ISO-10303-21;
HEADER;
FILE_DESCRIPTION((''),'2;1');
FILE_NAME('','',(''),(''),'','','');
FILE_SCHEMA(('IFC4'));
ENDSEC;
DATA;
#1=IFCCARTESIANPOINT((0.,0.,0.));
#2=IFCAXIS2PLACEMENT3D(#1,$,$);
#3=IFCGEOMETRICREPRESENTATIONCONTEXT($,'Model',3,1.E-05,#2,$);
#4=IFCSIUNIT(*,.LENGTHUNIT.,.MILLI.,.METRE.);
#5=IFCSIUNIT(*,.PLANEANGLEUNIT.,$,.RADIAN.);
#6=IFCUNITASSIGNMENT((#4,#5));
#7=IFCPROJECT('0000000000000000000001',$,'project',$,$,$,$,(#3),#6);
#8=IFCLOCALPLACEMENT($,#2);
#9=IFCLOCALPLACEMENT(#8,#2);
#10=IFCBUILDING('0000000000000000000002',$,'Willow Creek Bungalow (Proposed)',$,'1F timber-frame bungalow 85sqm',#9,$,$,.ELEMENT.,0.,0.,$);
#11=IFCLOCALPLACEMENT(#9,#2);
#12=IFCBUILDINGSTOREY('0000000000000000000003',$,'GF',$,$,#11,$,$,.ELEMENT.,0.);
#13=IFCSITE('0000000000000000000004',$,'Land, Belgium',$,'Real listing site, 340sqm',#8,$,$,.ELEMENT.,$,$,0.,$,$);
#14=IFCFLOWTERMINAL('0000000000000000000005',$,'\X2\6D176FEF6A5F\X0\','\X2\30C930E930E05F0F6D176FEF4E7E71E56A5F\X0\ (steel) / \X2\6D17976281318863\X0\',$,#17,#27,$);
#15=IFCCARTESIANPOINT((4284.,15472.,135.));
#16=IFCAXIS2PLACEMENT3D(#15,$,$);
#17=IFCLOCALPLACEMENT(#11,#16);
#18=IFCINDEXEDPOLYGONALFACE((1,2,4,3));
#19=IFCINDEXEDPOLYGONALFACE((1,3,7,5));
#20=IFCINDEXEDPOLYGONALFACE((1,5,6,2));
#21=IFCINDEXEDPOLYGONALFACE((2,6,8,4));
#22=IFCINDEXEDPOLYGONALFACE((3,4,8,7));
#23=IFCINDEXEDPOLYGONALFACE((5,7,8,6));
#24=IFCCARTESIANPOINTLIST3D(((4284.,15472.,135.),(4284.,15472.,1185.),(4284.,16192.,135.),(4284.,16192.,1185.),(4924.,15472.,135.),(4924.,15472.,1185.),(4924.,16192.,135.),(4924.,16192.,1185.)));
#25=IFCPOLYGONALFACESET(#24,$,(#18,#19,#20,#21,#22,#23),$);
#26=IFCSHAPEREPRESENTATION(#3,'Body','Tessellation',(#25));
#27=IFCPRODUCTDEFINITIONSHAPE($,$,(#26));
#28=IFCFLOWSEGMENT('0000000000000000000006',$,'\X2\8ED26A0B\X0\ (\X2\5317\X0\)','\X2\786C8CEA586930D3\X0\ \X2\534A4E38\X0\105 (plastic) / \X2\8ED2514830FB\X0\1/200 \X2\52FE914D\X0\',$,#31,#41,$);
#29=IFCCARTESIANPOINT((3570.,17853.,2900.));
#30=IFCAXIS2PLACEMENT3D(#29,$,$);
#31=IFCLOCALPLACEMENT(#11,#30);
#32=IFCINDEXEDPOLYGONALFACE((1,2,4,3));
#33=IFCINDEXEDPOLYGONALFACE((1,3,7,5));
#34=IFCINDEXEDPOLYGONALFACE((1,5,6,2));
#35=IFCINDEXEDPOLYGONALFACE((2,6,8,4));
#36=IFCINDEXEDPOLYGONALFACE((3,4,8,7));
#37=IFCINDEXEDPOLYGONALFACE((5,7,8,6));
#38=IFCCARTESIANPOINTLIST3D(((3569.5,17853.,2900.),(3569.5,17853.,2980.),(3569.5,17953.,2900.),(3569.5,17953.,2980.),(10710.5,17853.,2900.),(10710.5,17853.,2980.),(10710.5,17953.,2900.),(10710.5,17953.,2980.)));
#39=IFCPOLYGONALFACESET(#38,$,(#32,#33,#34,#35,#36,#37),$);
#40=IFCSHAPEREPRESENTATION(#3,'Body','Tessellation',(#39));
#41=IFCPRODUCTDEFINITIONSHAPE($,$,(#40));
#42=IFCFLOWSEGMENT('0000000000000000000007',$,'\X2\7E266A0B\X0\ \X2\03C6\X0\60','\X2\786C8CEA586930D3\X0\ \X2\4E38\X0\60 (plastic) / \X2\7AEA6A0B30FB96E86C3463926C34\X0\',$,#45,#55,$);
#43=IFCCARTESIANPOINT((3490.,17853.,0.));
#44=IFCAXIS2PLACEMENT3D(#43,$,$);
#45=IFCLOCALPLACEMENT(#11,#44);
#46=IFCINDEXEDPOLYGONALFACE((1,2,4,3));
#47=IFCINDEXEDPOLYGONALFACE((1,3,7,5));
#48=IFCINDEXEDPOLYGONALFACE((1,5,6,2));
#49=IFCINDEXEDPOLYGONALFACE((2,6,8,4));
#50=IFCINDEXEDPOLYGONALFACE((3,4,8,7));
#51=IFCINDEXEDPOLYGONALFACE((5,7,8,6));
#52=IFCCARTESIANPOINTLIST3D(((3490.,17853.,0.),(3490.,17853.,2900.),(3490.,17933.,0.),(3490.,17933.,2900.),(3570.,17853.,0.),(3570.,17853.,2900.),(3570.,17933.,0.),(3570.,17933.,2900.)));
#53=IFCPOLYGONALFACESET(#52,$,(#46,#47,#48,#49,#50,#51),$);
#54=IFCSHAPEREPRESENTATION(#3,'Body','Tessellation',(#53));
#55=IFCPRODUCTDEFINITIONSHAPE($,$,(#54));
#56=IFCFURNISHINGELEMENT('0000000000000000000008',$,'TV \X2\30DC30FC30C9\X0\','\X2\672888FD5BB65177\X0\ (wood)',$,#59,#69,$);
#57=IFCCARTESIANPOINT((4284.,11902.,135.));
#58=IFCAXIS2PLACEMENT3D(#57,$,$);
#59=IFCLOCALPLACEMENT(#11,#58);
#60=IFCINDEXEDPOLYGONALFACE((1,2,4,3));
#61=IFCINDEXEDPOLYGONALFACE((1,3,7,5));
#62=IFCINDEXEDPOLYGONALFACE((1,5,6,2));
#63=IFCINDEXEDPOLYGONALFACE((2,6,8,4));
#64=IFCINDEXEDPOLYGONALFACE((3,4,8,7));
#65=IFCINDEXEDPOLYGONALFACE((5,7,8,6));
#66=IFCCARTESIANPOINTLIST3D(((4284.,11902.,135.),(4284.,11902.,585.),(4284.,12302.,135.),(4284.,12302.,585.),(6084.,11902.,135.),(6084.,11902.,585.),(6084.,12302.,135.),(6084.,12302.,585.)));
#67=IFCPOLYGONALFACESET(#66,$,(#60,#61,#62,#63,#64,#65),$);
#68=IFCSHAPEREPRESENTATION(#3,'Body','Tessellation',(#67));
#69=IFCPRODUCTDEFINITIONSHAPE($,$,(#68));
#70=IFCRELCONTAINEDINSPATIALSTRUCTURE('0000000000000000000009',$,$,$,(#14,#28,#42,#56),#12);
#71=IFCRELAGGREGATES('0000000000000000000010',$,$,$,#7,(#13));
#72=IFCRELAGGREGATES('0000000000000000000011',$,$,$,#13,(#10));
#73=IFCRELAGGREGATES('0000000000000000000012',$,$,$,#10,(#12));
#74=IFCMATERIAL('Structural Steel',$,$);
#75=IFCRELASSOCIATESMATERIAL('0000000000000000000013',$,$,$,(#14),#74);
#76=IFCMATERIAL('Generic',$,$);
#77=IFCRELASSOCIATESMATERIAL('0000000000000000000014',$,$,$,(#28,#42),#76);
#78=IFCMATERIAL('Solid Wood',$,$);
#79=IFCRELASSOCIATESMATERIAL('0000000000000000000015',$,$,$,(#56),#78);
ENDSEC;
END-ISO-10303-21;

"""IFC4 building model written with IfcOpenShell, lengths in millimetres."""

from ifc_helpers import new_model, si_unit, frame, frame_2d, origin, place, context, project, spatial, rectangle, extrude, material, element, save


model = new_model("IFC4")

# Units and contexts
model_context = context("Model", 3, precision=1e-05, world=origin())
ifc_project = project(units=[si_unit("LENGTHUNIT", "METRE", prefix="MILLI"), si_unit("PLANEANGLEUNIT", "RADIAN")], contexts=[model_context])

# Site, building, storey
site_placement = place(None, origin())
site = spatial("IfcSite", under=ifc_project, at=site_placement, Name="Land, Belgium", ObjectType="Real listing site, 340sqm", CompositionType="ELEMENT", RefElevation=0.0)
building_placement = place(site_placement, origin())
building = spatial("IfcBuilding", under=site, at=building_placement, Name="Willow Creek Bungalow (Proposed)", ObjectType="1F timber-frame bungalow 85sqm", CompositionType="ELEMENT", ElevationOfRefHeight=0.0, ElevationOfTerrain=0.0)
storey_placement = place(building_placement, origin())
storey = spatial("IfcBuildingStorey", under=building, at=storey_placement, Name="GF", CompositionType="ELEMENT", Elevation=0.0)

# Shared definitions
ifc_material_1 = material(Name="Solid Wood")

# Shared definitions
ifc_material_2 = material(Name="Structural Steel")

# Shared definitions
ifc_material_3 = material(Name="Generic")

# Flow terminal
flow_terminal_placement = place(storey_placement, frame((4284.0, 15472.0, 135.0)))
element("IfcFlowTerminal", 1, at=flow_terminal_placement, inside=storey, material=ifc_material_2, Name="洗濯機", Description="ドラム式洗濯乾燥機 (steel) / 洗面脱衣", context=model_context, shape_type="SweptSolid", body=[
    extrude(rectangle(XDim=640.0, YDim=720.0, at=frame_2d((320.0, 360.0))), frame((4284.0, 15472.0, 135.0)), (0.0, 0.0, 1.0), 1050.0),
])

# Flow segments
flow_segment_1_placement = place(storey_placement, frame((3570.0, 17853.0, 2900.0)))
element("IfcFlowSegment", 2, at=flow_segment_1_placement, inside=storey, material=ifc_material_3, Name="軒樋 (北)", Description="硬質塩ビ 半丸105 (plastic) / 軒先・1/200 勾配", context=model_context, shape_type="SweptSolid", body=[
    extrude(rectangle(XDim=7141.0, YDim=100.0, at=frame_2d((3570.0, 50.0))), frame((3570.0, 17853.0, 2900.0)), (0.0, 0.0, 1.0), 80.0),
])
flow_segment_2_placement = place(storey_placement, frame((3490.0, 17853.0, 0.0)))
element("IfcFlowSegment", 3, at=flow_segment_2_placement, inside=storey, material=ifc_material_3, Name="縦樋 φ60", Description="硬質塩ビ 丸60 (plastic) / 竪樋・雨水排水", context=model_context, shape_type="SweptSolid", body=[
    extrude(rectangle(XDim=80.0, YDim=80.0, at=frame_2d((40.0, 40.0))), frame((3490.0, 17853.0, 0.0)), (0.0, 0.0, 1.0), 2900.0),
])

# Furnishing element
furnishing_placement = place(storey_placement, frame((4284.0, 11902.0, 135.0)))
element("IfcFurnishingElement", 4, at=furnishing_placement, inside=storey, material=ifc_material_1, Name="TV ボード", Description="木製家具 (wood)", context=model_context, shape_type="SweptSolid", body=[
    extrude(rectangle(XDim=1800.0, YDim=400.0, at=frame_2d((900.0, 200.0))), frame((4284.0, 11902.0, 135.0)), (0.0, 0.0, 1.0), 450.0),
])

save(model, "model.ifc")
